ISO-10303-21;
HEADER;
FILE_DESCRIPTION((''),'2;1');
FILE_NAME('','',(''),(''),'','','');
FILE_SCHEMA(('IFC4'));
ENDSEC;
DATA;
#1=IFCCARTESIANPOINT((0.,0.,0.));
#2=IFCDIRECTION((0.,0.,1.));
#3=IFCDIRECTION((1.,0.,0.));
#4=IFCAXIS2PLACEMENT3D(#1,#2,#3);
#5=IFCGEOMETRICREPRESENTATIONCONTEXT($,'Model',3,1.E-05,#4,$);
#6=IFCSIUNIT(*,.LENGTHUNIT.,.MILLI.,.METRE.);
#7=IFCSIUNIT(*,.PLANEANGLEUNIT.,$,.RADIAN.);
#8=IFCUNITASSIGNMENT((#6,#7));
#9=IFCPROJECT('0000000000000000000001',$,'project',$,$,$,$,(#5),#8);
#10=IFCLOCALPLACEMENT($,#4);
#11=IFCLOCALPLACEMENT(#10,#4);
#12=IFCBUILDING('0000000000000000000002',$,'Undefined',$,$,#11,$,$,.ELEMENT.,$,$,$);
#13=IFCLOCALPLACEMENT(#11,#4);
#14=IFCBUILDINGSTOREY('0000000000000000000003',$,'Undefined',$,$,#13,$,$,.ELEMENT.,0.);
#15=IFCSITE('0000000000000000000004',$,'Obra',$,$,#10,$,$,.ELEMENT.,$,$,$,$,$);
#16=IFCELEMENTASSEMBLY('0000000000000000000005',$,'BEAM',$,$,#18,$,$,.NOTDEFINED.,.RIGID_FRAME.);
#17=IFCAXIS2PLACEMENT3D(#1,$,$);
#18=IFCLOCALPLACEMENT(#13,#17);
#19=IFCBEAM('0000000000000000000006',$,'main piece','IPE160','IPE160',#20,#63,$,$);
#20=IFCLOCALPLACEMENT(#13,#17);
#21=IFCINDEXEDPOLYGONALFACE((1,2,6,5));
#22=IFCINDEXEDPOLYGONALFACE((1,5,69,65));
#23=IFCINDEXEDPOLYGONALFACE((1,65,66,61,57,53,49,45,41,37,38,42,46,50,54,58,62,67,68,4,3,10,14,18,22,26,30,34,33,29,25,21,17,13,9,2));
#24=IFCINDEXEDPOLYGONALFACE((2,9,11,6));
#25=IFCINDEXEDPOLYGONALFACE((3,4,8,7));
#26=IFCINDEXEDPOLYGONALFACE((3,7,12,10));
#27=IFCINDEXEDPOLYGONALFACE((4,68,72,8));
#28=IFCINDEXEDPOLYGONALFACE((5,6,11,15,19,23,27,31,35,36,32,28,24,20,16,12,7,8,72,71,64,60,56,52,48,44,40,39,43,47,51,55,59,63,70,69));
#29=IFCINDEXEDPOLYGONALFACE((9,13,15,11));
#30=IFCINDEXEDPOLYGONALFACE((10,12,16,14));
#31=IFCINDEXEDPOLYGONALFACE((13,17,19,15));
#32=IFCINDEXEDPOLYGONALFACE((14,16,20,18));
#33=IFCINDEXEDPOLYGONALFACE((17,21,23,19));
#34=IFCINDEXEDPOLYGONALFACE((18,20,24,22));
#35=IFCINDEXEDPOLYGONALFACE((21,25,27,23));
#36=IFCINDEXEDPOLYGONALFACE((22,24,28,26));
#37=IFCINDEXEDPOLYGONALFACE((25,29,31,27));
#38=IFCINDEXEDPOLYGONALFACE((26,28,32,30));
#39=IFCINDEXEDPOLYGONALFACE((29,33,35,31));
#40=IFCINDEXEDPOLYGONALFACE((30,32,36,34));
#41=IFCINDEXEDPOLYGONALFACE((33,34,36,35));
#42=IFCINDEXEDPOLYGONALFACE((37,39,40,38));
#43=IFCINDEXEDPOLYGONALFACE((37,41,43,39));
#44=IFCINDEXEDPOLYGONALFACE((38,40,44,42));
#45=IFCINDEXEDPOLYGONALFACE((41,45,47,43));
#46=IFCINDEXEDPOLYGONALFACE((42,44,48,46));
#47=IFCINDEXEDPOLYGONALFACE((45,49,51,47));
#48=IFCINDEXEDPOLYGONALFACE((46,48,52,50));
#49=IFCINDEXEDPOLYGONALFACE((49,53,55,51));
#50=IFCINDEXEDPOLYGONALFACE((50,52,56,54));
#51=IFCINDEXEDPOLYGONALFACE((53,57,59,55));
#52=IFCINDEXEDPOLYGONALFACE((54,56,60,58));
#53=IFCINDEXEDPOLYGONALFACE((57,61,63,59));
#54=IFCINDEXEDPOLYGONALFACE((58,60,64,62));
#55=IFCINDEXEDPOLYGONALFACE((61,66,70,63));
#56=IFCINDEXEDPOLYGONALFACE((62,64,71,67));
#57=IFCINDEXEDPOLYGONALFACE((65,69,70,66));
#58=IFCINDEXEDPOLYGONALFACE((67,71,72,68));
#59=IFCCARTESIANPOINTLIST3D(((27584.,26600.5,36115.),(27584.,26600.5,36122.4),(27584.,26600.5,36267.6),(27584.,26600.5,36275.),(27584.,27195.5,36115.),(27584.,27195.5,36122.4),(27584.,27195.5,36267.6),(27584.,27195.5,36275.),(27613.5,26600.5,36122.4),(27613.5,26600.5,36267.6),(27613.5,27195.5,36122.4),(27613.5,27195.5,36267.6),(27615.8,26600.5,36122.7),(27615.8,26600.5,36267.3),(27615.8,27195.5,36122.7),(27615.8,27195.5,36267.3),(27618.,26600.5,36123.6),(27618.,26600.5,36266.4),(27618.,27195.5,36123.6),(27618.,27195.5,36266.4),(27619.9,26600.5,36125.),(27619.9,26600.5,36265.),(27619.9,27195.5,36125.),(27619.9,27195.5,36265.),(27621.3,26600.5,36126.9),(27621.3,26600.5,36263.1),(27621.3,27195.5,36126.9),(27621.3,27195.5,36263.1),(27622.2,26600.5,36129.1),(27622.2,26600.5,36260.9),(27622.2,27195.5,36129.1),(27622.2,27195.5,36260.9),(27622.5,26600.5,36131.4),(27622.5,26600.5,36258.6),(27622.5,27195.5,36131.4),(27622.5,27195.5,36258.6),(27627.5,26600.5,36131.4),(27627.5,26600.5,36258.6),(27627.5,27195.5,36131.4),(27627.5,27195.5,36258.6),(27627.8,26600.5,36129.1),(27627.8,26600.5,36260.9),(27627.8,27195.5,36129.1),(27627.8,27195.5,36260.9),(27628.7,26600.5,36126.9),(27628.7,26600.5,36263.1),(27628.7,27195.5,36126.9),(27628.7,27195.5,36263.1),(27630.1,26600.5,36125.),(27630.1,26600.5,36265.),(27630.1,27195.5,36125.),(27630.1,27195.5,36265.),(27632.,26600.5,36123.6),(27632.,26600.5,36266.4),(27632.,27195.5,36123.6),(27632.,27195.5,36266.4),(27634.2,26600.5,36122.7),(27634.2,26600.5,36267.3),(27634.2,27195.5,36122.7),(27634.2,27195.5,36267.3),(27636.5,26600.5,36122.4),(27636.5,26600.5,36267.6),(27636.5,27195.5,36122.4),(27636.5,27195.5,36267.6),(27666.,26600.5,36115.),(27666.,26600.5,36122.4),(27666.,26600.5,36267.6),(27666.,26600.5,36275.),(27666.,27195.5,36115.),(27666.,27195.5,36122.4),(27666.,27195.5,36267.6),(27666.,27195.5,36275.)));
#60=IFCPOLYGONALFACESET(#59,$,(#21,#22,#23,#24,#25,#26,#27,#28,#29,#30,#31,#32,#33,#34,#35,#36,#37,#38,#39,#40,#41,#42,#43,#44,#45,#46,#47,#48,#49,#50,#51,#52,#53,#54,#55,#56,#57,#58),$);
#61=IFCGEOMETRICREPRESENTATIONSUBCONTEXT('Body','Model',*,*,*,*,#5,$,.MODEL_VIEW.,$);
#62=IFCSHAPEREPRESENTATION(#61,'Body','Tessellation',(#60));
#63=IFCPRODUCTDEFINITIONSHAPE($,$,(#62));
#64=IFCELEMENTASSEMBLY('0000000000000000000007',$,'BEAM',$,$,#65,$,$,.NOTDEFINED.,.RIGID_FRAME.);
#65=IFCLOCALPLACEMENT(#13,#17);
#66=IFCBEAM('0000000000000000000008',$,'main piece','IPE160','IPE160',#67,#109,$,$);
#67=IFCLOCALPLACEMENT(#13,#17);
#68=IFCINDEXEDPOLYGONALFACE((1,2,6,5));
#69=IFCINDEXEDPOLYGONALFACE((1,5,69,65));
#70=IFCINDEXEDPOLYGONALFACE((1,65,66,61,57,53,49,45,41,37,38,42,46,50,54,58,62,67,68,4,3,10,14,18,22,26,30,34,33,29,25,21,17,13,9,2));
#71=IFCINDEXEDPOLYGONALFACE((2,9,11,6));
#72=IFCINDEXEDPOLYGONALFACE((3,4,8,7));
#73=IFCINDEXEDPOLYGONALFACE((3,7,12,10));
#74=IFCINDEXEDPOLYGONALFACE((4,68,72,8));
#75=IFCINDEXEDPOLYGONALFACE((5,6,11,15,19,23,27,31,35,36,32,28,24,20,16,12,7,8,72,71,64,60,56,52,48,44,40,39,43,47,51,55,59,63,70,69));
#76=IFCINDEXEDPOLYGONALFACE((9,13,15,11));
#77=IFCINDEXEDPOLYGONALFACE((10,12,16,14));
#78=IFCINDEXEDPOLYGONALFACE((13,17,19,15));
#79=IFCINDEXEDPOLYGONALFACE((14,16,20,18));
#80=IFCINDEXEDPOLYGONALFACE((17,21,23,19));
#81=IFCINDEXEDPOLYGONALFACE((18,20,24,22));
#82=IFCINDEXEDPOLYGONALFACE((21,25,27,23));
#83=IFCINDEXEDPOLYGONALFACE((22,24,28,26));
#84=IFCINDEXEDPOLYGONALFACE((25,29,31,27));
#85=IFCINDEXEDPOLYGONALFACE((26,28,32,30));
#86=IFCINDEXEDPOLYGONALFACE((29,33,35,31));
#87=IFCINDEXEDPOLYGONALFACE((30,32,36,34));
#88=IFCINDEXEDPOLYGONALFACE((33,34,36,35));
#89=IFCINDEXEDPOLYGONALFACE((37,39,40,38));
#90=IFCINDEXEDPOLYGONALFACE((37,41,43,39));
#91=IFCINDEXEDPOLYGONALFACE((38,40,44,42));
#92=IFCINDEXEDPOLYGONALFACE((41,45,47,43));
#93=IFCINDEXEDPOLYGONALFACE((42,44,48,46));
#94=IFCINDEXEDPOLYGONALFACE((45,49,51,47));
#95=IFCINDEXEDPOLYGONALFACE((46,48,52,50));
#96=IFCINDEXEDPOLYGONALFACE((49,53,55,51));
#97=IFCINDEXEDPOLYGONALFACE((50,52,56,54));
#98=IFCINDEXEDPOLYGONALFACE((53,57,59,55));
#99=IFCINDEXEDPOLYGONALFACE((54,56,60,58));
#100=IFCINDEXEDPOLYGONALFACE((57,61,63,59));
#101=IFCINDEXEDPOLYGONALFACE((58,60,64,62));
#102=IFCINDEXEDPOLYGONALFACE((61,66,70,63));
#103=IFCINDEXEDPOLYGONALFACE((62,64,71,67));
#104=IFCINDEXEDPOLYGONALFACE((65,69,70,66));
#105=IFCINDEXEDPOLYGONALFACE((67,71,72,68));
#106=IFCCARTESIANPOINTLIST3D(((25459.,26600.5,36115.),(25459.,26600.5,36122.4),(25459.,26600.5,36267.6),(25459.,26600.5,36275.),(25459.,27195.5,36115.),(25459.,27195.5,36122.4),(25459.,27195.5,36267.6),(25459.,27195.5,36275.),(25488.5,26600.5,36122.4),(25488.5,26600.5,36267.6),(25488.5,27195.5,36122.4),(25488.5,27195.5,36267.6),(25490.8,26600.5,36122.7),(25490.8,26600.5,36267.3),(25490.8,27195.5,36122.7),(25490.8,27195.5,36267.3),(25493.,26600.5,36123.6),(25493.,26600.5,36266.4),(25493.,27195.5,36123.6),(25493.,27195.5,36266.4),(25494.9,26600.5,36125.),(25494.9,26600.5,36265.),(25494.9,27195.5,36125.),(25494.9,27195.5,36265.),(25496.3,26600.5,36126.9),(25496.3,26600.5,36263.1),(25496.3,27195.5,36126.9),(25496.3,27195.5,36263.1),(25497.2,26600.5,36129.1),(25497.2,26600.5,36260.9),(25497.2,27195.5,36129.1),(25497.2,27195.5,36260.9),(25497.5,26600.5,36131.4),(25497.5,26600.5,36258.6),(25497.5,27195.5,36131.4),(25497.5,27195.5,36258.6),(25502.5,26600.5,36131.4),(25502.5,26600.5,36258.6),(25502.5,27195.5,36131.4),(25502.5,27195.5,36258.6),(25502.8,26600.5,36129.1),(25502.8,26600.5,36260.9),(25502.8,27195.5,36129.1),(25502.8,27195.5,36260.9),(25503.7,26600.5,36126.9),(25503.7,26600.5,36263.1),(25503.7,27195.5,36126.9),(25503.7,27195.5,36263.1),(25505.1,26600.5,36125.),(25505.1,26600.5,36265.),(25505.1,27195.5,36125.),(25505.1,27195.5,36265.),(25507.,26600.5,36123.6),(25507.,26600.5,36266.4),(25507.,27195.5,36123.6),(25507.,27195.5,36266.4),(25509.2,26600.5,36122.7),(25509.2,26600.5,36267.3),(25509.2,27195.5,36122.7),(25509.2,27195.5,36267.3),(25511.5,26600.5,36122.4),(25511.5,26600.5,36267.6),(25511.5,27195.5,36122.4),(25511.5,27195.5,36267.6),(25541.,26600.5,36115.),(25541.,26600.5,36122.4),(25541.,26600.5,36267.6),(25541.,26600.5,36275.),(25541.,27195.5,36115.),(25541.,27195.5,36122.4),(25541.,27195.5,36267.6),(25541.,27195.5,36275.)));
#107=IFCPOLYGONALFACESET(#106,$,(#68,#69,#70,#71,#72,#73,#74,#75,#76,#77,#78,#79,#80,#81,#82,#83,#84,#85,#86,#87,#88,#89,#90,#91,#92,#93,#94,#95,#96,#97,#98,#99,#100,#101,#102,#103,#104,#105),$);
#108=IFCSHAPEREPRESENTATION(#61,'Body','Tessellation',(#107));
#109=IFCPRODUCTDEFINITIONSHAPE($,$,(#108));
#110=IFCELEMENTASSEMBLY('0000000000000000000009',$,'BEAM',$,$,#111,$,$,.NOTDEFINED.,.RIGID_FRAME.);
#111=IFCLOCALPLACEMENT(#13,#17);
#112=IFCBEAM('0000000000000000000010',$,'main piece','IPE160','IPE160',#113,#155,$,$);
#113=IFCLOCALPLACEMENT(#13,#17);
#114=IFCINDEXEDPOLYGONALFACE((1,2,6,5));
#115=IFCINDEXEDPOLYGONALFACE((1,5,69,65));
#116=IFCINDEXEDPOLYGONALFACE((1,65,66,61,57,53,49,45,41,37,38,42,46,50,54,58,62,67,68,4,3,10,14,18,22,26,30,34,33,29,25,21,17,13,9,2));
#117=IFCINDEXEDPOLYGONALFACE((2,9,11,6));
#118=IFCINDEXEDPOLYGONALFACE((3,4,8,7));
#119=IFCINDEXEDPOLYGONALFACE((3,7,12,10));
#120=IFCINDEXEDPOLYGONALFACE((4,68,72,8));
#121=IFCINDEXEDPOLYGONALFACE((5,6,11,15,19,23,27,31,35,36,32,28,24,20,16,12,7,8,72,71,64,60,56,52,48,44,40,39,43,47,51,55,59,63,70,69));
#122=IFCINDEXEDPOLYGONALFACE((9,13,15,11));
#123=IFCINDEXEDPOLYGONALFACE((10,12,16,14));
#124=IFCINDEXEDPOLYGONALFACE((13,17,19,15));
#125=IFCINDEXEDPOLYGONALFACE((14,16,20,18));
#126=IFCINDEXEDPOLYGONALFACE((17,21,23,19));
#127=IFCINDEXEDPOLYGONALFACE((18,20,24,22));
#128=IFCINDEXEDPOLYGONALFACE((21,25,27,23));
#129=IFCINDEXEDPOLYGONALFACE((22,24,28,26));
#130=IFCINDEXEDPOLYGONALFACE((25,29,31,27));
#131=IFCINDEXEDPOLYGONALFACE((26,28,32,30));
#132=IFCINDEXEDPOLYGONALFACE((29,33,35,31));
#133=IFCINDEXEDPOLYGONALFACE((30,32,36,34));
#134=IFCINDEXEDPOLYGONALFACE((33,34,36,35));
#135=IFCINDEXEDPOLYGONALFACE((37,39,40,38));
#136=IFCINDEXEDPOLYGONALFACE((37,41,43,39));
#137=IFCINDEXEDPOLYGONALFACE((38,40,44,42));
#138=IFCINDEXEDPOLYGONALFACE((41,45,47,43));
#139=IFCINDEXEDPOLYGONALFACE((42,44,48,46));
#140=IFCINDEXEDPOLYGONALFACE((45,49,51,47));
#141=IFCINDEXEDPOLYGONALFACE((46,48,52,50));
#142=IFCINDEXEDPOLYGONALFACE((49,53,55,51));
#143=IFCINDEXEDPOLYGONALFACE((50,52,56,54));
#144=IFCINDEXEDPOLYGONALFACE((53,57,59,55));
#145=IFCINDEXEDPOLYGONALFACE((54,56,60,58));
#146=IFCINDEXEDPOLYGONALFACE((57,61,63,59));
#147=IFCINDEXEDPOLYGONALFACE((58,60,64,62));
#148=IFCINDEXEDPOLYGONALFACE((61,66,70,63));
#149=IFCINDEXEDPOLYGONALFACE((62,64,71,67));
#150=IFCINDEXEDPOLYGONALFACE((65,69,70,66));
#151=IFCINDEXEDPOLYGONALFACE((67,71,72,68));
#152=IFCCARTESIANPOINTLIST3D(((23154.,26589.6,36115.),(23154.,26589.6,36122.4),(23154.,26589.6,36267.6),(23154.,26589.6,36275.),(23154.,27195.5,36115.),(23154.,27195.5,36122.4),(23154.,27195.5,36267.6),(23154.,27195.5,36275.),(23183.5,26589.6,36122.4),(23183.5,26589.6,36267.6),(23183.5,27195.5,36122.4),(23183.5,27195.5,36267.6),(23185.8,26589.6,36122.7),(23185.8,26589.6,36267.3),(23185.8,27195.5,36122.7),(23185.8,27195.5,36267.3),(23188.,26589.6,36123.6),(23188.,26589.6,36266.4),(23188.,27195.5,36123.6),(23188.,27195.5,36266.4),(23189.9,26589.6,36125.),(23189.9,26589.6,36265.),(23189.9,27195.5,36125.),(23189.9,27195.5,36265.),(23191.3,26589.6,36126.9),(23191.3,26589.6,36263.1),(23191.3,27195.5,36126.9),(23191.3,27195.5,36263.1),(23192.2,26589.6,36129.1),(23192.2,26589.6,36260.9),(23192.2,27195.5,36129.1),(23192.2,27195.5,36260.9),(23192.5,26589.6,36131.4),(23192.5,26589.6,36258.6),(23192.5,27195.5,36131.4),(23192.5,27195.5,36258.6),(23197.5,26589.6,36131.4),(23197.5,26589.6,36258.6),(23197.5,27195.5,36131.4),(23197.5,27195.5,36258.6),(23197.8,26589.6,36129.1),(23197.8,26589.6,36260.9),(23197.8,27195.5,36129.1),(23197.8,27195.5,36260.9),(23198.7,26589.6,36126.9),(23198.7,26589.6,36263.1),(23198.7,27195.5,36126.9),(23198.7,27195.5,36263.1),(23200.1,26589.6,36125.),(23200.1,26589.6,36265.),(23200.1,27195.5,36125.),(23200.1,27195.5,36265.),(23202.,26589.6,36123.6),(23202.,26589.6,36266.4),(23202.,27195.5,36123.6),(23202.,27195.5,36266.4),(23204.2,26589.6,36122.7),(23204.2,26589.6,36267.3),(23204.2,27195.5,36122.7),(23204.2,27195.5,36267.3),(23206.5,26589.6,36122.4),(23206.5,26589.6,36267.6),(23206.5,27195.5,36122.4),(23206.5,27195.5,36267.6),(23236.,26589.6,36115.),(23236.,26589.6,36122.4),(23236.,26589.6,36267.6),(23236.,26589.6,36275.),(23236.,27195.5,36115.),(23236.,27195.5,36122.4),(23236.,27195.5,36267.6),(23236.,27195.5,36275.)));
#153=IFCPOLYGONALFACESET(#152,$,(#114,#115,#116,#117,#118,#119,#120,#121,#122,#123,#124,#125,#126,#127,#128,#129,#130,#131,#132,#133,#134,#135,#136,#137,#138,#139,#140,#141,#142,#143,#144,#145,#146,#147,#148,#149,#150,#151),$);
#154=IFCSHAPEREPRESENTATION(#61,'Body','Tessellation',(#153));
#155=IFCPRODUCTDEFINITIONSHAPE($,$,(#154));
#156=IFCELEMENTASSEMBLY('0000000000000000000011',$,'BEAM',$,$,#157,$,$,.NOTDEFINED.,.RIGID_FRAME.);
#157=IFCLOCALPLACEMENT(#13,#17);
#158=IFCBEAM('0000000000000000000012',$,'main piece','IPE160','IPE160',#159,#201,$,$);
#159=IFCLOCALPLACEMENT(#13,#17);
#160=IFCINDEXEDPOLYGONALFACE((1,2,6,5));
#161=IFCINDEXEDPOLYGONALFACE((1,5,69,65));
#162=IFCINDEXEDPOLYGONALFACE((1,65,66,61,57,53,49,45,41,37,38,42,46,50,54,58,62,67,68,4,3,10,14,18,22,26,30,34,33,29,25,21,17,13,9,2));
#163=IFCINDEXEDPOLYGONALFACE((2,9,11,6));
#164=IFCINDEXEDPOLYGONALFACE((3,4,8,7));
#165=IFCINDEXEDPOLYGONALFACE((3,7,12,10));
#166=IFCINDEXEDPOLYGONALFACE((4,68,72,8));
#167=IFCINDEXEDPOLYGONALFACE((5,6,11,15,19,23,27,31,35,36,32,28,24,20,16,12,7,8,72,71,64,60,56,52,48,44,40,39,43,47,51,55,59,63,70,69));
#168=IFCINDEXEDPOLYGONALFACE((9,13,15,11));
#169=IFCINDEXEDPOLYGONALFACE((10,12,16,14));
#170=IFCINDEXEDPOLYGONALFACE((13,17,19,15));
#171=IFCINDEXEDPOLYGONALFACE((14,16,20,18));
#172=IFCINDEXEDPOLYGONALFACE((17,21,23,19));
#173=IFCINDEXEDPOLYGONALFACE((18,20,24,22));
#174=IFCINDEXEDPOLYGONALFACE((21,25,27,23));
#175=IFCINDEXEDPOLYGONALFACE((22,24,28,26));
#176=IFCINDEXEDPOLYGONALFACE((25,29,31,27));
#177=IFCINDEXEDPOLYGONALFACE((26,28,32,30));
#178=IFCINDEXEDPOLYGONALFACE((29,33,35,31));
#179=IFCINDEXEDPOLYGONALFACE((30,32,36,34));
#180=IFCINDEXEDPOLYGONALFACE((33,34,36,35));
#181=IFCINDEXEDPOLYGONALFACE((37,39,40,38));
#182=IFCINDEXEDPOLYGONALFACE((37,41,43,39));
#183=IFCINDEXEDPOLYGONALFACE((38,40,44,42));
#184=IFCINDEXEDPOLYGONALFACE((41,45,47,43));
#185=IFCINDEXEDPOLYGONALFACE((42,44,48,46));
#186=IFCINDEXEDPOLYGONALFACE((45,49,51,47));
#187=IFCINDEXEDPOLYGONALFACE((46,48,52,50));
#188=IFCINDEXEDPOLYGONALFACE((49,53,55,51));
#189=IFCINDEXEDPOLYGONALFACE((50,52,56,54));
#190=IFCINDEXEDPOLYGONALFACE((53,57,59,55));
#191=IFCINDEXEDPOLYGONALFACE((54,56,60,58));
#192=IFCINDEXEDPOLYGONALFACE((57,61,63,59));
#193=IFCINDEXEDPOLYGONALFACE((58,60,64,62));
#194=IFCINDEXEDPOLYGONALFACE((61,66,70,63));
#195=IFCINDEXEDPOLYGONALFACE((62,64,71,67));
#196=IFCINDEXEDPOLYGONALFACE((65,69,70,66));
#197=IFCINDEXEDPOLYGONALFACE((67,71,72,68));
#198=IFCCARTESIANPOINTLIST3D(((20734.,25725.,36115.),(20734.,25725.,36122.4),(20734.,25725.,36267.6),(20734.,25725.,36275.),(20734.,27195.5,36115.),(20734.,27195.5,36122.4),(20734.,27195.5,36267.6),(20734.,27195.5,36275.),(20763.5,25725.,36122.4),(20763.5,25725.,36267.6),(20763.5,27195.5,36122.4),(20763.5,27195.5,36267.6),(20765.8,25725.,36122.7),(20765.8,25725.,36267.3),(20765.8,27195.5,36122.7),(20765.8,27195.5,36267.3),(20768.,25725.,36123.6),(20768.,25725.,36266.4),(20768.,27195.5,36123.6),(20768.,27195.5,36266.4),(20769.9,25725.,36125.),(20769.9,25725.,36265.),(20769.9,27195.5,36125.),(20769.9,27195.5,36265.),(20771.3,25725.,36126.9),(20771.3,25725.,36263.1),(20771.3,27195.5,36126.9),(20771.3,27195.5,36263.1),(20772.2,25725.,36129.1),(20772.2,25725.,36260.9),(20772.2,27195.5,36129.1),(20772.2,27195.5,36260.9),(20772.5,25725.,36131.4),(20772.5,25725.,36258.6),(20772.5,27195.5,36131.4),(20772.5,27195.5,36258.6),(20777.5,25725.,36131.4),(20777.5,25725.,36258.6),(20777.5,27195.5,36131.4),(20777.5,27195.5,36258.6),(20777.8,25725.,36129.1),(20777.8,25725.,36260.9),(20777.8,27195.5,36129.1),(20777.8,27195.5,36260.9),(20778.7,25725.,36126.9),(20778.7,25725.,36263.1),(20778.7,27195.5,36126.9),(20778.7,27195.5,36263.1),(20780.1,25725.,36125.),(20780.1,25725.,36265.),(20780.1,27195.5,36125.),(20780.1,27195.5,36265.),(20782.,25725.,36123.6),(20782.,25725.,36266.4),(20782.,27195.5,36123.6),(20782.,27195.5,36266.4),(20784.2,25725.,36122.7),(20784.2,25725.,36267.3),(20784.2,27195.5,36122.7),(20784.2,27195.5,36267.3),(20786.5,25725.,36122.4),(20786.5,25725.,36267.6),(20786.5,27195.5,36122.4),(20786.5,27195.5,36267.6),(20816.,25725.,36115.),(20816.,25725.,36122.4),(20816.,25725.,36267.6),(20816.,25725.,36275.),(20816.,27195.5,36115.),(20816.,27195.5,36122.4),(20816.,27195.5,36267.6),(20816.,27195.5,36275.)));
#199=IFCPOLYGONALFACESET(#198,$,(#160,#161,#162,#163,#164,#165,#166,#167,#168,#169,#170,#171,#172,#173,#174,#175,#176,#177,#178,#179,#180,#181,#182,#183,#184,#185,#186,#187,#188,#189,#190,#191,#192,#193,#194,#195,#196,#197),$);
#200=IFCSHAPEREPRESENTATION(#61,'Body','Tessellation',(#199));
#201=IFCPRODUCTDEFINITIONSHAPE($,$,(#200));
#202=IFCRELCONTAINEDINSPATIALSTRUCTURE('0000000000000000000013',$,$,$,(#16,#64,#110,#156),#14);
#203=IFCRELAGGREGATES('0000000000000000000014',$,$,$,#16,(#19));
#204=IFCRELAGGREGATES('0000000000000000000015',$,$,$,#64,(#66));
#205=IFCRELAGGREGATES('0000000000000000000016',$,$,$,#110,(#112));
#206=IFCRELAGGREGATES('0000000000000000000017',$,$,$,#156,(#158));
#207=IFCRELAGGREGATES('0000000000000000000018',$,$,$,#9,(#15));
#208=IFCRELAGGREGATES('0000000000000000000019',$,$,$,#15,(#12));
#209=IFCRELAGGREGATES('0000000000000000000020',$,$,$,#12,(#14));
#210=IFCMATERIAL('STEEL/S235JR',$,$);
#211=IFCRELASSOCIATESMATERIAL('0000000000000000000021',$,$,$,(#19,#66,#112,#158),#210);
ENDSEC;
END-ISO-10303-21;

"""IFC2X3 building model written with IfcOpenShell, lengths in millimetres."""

from ifc_helpers import new_model, si_unit, frame, origin_with_axes, origin_2d_with_axis, place, context, subcontext, project, spatial, i_section, extrude, material, element, aggregate, save


model = new_model("IFC2X3")

# Units and contexts
model_context = context("Model", 3, precision=1e-05, world=origin_with_axes())
body_context = subcontext(model_context, "Body", "Model", "MODEL_VIEW")
ifc_project = project(units=[si_unit("LENGTHUNIT", "METRE", prefix="MILLI"), si_unit("PLANEANGLEUNIT", "RADIAN")], contexts=[model_context])

# Site, building, storey
site_placement = place(None, origin_with_axes())
site = spatial("IfcSite", under=ifc_project, at=site_placement, Name="Obra", CompositionType="ELEMENT")
building_placement = place(site_placement, origin_with_axes())
building = spatial("IfcBuilding", under=site, at=building_placement, Name="Undefined", CompositionType="ELEMENT")
storey_placement = place(building_placement, origin_with_axes())
storey = spatial("IfcBuildingStorey", under=building, at=storey_placement, Name="Undefined", CompositionType="ELEMENT", Elevation=0.0)

# Shared definitions
ifc_material_1 = material(Name="STEEL/S235JR")

# Element assemblies, beams
assembly_1_placement = place(storey_placement, origin_with_axes())
assembly_1 = element("IfcElementAssembly", 1, at=assembly_1_placement, inside=storey, Name="BEAM", AssemblyPlace="NOTDEFINED", PredefinedType="RIGID_FRAME")
beam_1_placement = place(assembly_1_placement, frame((27625.0, 26600.5, 36195.0), z_axis=(0.0, 0.0, 1.0), x_axis=(0.0, 1.0, 0.0)))
beam_1 = element("IfcBeam", 2, at=beam_1_placement, material=ifc_material_1, Name="main piece", Description="IPE160", ObjectType="IPE160", context=body_context, shape_type="SweptSolid", body=[
    extrude(i_section(OverallWidth=82.0, OverallDepth=160.0, WebThickness=5.0, FlangeThickness=7.4, FilletRadius=9.0, at=origin_2d_with_axis()), frame((595.0, 0.0, 0.0), z_axis=(-1.0, 0.0, 0.0), x_axis=(0.0, -1.0, 0.0)), (0.0, 0.0, 1.0), 595.0),
])
aggregate(assembly_1, [beam_1])
assembly_2_placement = place(storey_placement, origin_with_axes())
assembly_2 = element("IfcElementAssembly", 3, at=assembly_2_placement, inside=storey, Name="BEAM", AssemblyPlace="NOTDEFINED", PredefinedType="RIGID_FRAME")
beam_2_placement = place(assembly_2_placement, frame((25500.0, 26600.5, 36195.0), z_axis=(0.0, 0.0, 1.0), x_axis=(0.0, 1.0, 0.0)))
beam_2 = element("IfcBeam", 4, at=beam_2_placement, material=ifc_material_1, Name="main piece", Description="IPE160", ObjectType="IPE160", context=body_context, shape_type="SweptSolid", body=[
    extrude(i_section(OverallWidth=82.0, OverallDepth=160.0, WebThickness=5.0, FlangeThickness=7.4, FilletRadius=9.0, at=origin_2d_with_axis()), frame((595.0, 0.0, 0.0), z_axis=(-1.0, 0.0, 0.0), x_axis=(0.0, -1.0, 0.0)), (0.0, 0.0, 1.0), 595.0),
])
aggregate(assembly_2, [beam_2])
assembly_3_placement = place(storey_placement, origin_with_axes())
assembly_3 = element("IfcElementAssembly", 5, at=assembly_3_placement, inside=storey, Name="BEAM", AssemblyPlace="NOTDEFINED", PredefinedType="RIGID_FRAME")
beam_3_placement = place(assembly_3_placement, frame((23195.0, 26589.6, 36195.0), z_axis=(0.0, 0.0, 1.0), x_axis=(0.0, 1.0, 0.0)))
beam_3 = element("IfcBeam", 6, at=beam_3_placement, material=ifc_material_1, Name="main piece", Description="IPE160", ObjectType="IPE160", context=body_context, shape_type="SweptSolid", body=[
    extrude(i_section(OverallWidth=82.0, OverallDepth=160.0, WebThickness=5.0, FlangeThickness=7.4, FilletRadius=9.0, at=origin_2d_with_axis()), frame((605.9, 0.0, 0.0), z_axis=(-1.0, 0.0, 0.0), x_axis=(0.0, -1.0, 0.0)), (0.0, 0.0, 1.0), 605.9),
])
aggregate(assembly_3, [beam_3])
assembly_4_placement = place(storey_placement, origin_with_axes())
assembly_4 = element("IfcElementAssembly", 7, at=assembly_4_placement, inside=storey, Name="BEAM", AssemblyPlace="NOTDEFINED", PredefinedType="RIGID_FRAME")
beam_4_placement = place(assembly_4_placement, frame((20775.0, 25725.0, 36195.0), z_axis=(0.0, 0.0, 1.0), x_axis=(0.0, 1.0, 0.0)))
beam_4 = element("IfcBeam", 8, at=beam_4_placement, material=ifc_material_1, Name="main piece", Description="IPE160", ObjectType="IPE160", context=body_context, shape_type="SweptSolid", body=[
    extrude(i_section(OverallWidth=82.0, OverallDepth=160.0, WebThickness=5.0, FlangeThickness=7.4, FilletRadius=9.0, at=origin_2d_with_axis()), frame((1470.5, 0.0, 0.0), z_axis=(-1.0, 0.0, 0.0), x_axis=(0.0, -1.0, 0.0)), (0.0, 0.0, 1.0), 1470.5),
])
aggregate(assembly_4, [beam_4])

save(model, "model.ifc")
